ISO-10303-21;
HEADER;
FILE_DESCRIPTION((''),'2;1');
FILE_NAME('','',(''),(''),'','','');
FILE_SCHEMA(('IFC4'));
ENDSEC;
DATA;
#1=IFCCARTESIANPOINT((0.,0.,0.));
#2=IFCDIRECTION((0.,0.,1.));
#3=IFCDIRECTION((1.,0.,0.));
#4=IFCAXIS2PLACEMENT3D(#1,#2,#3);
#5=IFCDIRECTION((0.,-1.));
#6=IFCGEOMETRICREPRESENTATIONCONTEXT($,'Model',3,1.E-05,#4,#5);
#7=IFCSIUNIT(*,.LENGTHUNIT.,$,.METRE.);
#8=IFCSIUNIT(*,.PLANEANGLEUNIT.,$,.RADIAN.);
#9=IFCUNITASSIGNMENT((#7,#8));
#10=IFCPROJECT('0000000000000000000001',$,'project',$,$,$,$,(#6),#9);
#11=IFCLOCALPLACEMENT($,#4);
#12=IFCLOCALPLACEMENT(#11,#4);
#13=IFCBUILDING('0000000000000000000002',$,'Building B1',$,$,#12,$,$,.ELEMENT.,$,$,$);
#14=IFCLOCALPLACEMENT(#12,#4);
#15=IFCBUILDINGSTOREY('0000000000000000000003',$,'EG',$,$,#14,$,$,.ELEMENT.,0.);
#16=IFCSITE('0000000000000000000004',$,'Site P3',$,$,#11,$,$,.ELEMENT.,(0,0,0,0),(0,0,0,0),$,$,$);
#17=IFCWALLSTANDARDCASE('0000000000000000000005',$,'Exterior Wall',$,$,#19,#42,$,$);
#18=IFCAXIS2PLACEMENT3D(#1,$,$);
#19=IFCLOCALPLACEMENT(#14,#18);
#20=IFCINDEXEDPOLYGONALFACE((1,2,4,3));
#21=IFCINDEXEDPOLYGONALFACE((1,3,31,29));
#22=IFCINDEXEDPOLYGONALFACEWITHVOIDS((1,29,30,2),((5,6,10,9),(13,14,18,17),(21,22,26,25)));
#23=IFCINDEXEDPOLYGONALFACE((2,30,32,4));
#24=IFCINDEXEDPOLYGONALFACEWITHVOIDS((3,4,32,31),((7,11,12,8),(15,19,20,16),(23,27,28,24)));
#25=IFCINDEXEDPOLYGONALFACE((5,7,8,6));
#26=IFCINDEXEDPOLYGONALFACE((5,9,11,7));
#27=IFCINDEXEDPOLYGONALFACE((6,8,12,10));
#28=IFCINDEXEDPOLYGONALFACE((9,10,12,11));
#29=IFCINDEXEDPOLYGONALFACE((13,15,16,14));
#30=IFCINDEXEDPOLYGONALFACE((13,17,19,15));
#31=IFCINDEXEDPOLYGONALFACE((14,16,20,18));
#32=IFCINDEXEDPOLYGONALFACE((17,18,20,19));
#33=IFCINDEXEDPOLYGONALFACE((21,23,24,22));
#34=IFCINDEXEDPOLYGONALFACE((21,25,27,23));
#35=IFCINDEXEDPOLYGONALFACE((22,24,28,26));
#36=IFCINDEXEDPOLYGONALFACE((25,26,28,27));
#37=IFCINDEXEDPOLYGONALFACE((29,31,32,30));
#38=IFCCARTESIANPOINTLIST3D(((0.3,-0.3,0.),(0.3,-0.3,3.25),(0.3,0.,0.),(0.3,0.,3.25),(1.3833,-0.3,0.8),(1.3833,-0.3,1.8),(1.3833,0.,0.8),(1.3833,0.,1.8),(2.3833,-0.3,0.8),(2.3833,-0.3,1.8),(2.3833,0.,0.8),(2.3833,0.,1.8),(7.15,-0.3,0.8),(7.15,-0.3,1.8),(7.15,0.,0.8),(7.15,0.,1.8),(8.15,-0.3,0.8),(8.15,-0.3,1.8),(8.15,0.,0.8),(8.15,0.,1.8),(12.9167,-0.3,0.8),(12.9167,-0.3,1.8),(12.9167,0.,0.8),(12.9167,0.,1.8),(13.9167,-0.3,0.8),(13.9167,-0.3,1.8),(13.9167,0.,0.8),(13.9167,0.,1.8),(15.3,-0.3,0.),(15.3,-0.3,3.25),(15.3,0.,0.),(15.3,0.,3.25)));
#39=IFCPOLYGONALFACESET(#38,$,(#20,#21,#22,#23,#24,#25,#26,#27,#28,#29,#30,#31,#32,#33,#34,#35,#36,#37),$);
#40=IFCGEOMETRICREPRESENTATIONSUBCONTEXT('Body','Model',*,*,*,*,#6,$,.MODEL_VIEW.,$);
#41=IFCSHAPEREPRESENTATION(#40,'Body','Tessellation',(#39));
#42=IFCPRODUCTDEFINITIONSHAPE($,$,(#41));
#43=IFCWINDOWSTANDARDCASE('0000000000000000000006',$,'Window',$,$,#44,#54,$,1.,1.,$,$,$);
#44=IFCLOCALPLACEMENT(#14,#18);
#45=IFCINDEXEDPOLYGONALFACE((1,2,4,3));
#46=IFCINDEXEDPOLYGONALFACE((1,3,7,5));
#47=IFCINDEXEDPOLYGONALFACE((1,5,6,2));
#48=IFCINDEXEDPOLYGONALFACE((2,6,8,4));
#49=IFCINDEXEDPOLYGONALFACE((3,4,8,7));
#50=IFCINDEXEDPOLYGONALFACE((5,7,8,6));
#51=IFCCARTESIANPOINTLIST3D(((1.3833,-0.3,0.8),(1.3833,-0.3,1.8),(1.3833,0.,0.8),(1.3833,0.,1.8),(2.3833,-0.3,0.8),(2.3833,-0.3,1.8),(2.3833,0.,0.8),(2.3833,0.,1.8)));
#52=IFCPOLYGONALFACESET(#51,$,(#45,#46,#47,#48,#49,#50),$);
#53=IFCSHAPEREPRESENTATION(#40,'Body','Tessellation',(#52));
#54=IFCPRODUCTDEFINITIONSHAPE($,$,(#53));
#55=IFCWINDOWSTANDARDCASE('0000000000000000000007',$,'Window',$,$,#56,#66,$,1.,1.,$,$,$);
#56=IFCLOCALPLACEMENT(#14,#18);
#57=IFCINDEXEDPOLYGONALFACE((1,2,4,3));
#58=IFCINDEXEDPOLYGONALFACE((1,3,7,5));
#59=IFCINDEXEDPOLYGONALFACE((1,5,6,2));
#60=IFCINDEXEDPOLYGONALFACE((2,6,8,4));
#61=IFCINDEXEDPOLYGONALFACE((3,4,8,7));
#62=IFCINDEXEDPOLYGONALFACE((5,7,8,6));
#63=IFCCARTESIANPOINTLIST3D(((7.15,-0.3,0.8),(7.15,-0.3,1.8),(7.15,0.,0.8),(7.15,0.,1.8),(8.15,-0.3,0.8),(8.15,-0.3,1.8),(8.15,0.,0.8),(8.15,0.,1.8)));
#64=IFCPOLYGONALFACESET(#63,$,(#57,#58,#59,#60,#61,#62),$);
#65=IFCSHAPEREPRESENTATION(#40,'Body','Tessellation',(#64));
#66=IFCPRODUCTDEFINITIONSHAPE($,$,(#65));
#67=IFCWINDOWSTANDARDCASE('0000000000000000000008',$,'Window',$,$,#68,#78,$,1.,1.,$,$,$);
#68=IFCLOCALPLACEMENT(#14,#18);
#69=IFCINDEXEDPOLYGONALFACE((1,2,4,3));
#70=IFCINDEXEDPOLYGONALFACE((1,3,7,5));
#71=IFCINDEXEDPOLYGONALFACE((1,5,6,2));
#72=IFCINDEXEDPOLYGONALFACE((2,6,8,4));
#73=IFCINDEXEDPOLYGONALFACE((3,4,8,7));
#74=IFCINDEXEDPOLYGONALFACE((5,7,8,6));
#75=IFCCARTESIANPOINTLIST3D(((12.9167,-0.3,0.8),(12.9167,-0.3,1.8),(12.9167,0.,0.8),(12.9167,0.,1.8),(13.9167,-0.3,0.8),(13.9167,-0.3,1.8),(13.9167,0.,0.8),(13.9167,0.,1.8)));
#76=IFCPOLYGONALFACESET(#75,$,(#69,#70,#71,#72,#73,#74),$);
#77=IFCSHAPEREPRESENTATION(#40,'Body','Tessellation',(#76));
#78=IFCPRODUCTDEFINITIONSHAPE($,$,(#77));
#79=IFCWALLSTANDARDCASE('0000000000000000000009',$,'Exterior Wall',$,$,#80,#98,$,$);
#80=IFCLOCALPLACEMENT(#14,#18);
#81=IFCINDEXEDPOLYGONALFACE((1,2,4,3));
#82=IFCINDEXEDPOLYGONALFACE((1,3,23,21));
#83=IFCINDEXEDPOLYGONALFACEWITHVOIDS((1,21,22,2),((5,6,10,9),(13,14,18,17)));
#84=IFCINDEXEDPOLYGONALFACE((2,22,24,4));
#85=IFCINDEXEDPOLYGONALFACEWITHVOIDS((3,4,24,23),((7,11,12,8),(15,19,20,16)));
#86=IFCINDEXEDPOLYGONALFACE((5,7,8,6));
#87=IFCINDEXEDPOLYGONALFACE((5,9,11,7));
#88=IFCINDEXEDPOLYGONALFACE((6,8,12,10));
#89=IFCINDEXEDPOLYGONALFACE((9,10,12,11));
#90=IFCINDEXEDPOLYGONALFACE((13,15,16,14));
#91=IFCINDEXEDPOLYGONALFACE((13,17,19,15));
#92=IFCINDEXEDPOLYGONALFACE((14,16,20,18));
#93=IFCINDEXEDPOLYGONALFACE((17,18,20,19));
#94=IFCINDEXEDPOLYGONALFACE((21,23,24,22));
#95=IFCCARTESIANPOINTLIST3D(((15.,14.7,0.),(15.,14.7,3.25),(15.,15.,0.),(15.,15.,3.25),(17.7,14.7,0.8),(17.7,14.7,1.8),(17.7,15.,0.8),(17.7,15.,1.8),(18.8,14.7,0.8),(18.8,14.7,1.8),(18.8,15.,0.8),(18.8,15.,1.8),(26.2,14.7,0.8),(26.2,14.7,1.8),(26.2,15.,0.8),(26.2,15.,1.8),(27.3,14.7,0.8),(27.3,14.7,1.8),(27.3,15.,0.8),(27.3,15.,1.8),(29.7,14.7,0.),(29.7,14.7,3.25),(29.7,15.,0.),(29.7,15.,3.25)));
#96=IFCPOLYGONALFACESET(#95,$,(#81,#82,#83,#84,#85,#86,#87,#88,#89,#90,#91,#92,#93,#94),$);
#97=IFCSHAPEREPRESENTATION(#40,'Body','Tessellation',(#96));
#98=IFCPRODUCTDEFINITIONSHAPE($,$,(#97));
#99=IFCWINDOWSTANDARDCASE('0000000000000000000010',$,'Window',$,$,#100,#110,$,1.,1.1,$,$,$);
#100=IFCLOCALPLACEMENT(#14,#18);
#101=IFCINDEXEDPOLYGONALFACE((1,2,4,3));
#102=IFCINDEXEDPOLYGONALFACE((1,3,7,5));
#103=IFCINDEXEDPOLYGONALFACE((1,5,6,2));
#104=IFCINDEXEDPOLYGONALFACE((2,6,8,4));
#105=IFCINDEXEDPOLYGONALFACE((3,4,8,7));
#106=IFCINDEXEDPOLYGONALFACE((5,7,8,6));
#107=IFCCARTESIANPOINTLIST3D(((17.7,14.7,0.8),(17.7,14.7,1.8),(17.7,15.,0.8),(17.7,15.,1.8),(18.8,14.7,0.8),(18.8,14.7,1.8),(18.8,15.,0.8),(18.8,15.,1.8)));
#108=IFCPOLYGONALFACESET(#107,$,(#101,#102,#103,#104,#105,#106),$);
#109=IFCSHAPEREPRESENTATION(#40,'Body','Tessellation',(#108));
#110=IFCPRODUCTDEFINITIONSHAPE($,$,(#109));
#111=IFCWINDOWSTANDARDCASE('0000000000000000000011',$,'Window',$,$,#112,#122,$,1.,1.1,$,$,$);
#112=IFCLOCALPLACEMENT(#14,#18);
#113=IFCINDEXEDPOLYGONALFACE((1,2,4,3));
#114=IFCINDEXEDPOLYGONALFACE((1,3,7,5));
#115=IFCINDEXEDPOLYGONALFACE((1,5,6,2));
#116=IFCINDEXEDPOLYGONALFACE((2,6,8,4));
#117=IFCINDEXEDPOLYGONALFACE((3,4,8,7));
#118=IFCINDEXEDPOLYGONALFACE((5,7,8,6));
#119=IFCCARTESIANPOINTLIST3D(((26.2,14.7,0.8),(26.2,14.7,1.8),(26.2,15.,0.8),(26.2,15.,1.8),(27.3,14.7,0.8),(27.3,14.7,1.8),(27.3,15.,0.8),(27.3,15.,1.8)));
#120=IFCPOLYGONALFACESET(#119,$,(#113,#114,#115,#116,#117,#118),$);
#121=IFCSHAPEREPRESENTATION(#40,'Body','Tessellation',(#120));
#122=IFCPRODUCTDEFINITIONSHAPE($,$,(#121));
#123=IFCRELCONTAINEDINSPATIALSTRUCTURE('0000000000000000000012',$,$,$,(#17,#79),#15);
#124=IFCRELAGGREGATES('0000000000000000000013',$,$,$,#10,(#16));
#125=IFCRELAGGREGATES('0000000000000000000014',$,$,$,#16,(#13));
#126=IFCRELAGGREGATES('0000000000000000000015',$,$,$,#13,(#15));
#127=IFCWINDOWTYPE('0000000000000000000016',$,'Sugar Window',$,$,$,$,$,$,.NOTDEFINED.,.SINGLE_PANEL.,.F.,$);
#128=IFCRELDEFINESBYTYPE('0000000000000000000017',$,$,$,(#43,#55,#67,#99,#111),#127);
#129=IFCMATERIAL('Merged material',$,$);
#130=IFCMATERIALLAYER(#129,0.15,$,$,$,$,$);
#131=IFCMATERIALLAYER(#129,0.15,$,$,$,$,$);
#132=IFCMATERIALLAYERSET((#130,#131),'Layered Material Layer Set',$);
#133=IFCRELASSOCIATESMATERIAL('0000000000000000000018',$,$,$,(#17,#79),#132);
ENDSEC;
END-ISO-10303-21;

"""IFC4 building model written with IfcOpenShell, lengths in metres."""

from ifc_helpers import new_model, si_unit, direction, frame, origin_with_axes, place, context, subcontext, project, spatial, polyline, outline, extrude, source, transform, mapped, material, layer, layer_set, layer_usage, type_object, element, fill, save


model = new_model("IFC4")

# Units and contexts
model_context = context("Model", 3, precision=1e-05, world=origin_with_axes(), true_north=direction((0.0, -1.0)))
body_context = subcontext(model_context, "Body", "Model", "MODEL_VIEW")
ifc_project = project(units=[si_unit("LENGTHUNIT", "METRE"), si_unit("PLANEANGLEUNIT", "RADIAN")], contexts=[model_context])

# Site, building, storey
site_placement = place(None, origin_with_axes())
site = spatial("IfcSite", under=ifc_project, at=site_placement, Name="Site P3", CompositionType="ELEMENT", RefLatitude=(0, 0, 0, 0), RefLongitude=(0, 0, 0, 0))
building_placement = place(site_placement, origin_with_axes())
building = spatial("IfcBuilding", under=site, at=building_placement, Name="Building B1", CompositionType="ELEMENT")
storey_placement = place(building_placement, origin_with_axes())
storey = spatial("IfcBuildingStorey", under=building, at=storey_placement, Name="EG", CompositionType="ELEMENT", Elevation=0.0)

# Walls, openings, windows
ifc_material = material(Name="Merged material")
ifc_layer_1 = layer(ifc_material, 0.15)
ifc_layer_2 = layer(ifc_material, 0.15)
ifc_layer_set_1 = layer_set([ifc_layer_1, ifc_layer_2], Name="Layered Material Layer Set")
ifc_layer_usage_1 = layer_usage(ifc_layer_set_1, "AXIS2", "POSITIVE", -0.15)
wall_1_placement = place(storey_placement, frame((15.3, -0.15, 0.0), z_axis=(0.0, 0.0, 1.0), x_axis=(-1.0, 0.0, 0.0)))
wall_1 = element("IfcWallStandardCase", 1, at=wall_1_placement, inside=storey, material=ifc_layer_usage_1, Name="Exterior Wall", context=body_context, shape_type="SweptSolid", body=[
    extrude(outline(polyline([(0.0, 0.15), (15.0, 0.15), (15.0, -0.15), (0.0, -0.15), (0.0, 0.15)])), origin_with_axes(), (0.0, 0.0, 1.0), 3.25),
])
opening_1_placement = place(wall_1_placement, frame((12.9167, 0.0, 0.8), z_axis=(0.0, 0.0, 1.0), x_axis=(1.0, 0.0, 0.0)))
opening_1 = element("IfcOpeningStandardCase", 2, at=opening_1_placement, cuts=wall_1, context=body_context, shape_type="SweptSolid", body=[
    extrude(outline(polyline([(0.0, 0.0), (0.0, 1.0), (1.0, 1.0), (1.0, 0.0), (0.0, 0.0)])), frame((0.0, -0.15, 0.0), z_axis=(0.0, 1.0, 0.0), x_axis=(0.0, 0.0, 1.0)), (0.0, 0.0, 1.0), 0.3),
])
opening_2_placement = place(wall_1_placement, frame((7.15, 0.0, 0.8), z_axis=(0.0, 0.0, 1.0), x_axis=(1.0, 0.0, 0.0)))
opening_2 = element("IfcOpeningStandardCase", 3, at=opening_2_placement, cuts=wall_1, context=body_context, shape_type="SweptSolid", body=[
    extrude(outline(polyline([(0.0, 0.0), (0.0, 1.0), (1.0, 1.0), (1.0, 0.0), (0.0, 0.0)])), frame((0.0, -0.15, 0.0), z_axis=(0.0, 1.0, 0.0), x_axis=(0.0, 0.0, 1.0)), (0.0, 0.0, 1.0), 0.3),
])
opening_3_placement = place(wall_1_placement, frame((1.3833, 0.0, 0.8), z_axis=(0.0, 0.0, 1.0), x_axis=(1.0, 0.0, 0.0)))
opening_3 = element("IfcOpeningStandardCase", 4, at=opening_3_placement, cuts=wall_1, context=body_context, shape_type="SweptSolid", body=[
    extrude(outline(polyline([(0.0, 0.0), (0.0, 1.0), (1.0, 1.0), (1.0, 0.0), (0.0, 0.0)])), frame((0.0, -0.15, 0.0), z_axis=(0.0, 1.0, 0.0), x_axis=(0.0, 0.0, 1.0)), (0.0, 0.0, 1.0), 0.3),
])
window_type = type_object("IfcWindowType", Name="Sugar Window", ParameterTakesPrecedence=False, PartitioningType="SINGLE_PANEL", PredefinedType="NOTDEFINED")
shared_shape_1 = source(origin_with_axes(), body_context, "Body", "SweptSolid", [
    extrude(outline(polyline([(0.0, 0.0), (0.0, 1.0), (1.0, 1.0), (1.0, 0.0), (0.0, 0.0)])), frame((0.0, -0.15, 0.0), z_axis=(0.0, 1.0, 0.0), x_axis=(0.0, 0.0, 1.0)), (0.0, 0.0, 1.0), 0.3),
])
window_1_placement = place(opening_1_placement, origin_with_axes())
window_1 = element("IfcWindowStandardCase", 5, at=window_1_placement, type_object=window_type, Name="Window", OverallHeight=1.0, OverallWidth=1.0, context=body_context, shape_type="MappedRepresentation", body=[
    mapped(shared_shape_1, transform((0.0, 0.0, 0.0))),
])
fill(opening_1, window_1)
window_2_placement = place(opening_2_placement, origin_with_axes())
window_2 = element("IfcWindowStandardCase", 6, at=window_2_placement, type_object=window_type, Name="Window", OverallHeight=1.0, OverallWidth=1.0, context=body_context, shape_type="MappedRepresentation", body=[
    mapped(shared_shape_1, transform((0.0, 0.0, 0.0))),
])
fill(opening_2, window_2)
window_3_placement = place(opening_3_placement, origin_with_axes())
window_3 = element("IfcWindowStandardCase", 7, at=window_3_placement, type_object=window_type, Name="Window", OverallHeight=1.0, OverallWidth=1.0, context=body_context, shape_type="MappedRepresentation", body=[
    mapped(shared_shape_1, transform((0.0, 0.0, 0.0))),
])
fill(opening_3, window_3)
wall_2_placement = place(storey_placement, frame((29.7, 14.85, 0.0), z_axis=(0.0, 0.0, 1.0), x_axis=(-1.0, 0.0, 0.0)))
wall_2 = element("IfcWallStandardCase", 8, at=wall_2_placement, inside=storey, material=ifc_layer_usage_1, Name="Exterior Wall", context=body_context, shape_type="SweptSolid", body=[
    extrude(outline(polyline([(0.0, 0.15), (14.7, 0.15), (14.7, -0.15), (0.0, -0.15), (0.0, 0.15)])), origin_with_axes(), (0.0, 0.0, 1.0), 3.25),
])
opening_4_placement = place(wall_2_placement, frame((10.9, 0.0, 0.8), z_axis=(0.0, 0.0, 1.0), x_axis=(1.0, 0.0, 0.0)))
opening_4 = element("IfcOpeningStandardCase", 9, at=opening_4_placement, cuts=wall_2, context=body_context, shape_type="SweptSolid", body=[
    extrude(outline(polyline([(0.0, 0.0), (0.0, 1.1), (1.0, 1.1), (1.0, 0.0), (0.0, 0.0)])), frame((0.0, -0.15, 0.0), z_axis=(0.0, 1.0, 0.0), x_axis=(0.0, 0.0, 1.0)), (0.0, 0.0, 1.0), 0.3),
])
opening_5_placement = place(wall_2_placement, frame((2.4, 0.0, 0.8), z_axis=(0.0, 0.0, 1.0), x_axis=(1.0, 0.0, 0.0)))
opening_5 = element("IfcOpeningStandardCase", 10, at=opening_5_placement, cuts=wall_2, context=body_context, shape_type="SweptSolid", body=[
    extrude(outline(polyline([(0.0, 0.0), (0.0, 1.1), (1.0, 1.1), (1.0, 0.0), (0.0, 0.0)])), frame((0.0, -0.15, 0.0), z_axis=(0.0, 1.0, 0.0), x_axis=(0.0, 0.0, 1.0)), (0.0, 0.0, 1.0), 0.3),
])
shared_shape_2 = source(origin_with_axes(), body_context, "Body", "SweptSolid", [
    extrude(outline(polyline([(0.0, 0.0), (0.0, 1.1), (1.0, 1.1), (1.0, 0.0), (0.0, 0.0)])), frame((0.0, -0.15, 0.0), z_axis=(0.0, 1.0, 0.0), x_axis=(0.0, 0.0, 1.0)), (0.0, 0.0, 1.0), 0.3),
])
window_4_placement = place(opening_4_placement, origin_with_axes())
window_4 = element("IfcWindowStandardCase", 11, at=window_4_placement, type_object=window_type, Name="Window", OverallHeight=1.0, OverallWidth=1.1, context=body_context, shape_type="MappedRepresentation", body=[
    mapped(shared_shape_2, transform((0.0, 0.0, 0.0))),
])
fill(opening_4, window_4)
window_5_placement = place(opening_5_placement, origin_with_axes())
window_5 = element("IfcWindowStandardCase", 12, at=window_5_placement, type_object=window_type, Name="Window", OverallHeight=1.0, OverallWidth=1.1, context=body_context, shape_type="MappedRepresentation", body=[
    mapped(shared_shape_2, transform((0.0, 0.0, 0.0))),
])
fill(opening_5, window_5)

save(model, "model.ifc")
